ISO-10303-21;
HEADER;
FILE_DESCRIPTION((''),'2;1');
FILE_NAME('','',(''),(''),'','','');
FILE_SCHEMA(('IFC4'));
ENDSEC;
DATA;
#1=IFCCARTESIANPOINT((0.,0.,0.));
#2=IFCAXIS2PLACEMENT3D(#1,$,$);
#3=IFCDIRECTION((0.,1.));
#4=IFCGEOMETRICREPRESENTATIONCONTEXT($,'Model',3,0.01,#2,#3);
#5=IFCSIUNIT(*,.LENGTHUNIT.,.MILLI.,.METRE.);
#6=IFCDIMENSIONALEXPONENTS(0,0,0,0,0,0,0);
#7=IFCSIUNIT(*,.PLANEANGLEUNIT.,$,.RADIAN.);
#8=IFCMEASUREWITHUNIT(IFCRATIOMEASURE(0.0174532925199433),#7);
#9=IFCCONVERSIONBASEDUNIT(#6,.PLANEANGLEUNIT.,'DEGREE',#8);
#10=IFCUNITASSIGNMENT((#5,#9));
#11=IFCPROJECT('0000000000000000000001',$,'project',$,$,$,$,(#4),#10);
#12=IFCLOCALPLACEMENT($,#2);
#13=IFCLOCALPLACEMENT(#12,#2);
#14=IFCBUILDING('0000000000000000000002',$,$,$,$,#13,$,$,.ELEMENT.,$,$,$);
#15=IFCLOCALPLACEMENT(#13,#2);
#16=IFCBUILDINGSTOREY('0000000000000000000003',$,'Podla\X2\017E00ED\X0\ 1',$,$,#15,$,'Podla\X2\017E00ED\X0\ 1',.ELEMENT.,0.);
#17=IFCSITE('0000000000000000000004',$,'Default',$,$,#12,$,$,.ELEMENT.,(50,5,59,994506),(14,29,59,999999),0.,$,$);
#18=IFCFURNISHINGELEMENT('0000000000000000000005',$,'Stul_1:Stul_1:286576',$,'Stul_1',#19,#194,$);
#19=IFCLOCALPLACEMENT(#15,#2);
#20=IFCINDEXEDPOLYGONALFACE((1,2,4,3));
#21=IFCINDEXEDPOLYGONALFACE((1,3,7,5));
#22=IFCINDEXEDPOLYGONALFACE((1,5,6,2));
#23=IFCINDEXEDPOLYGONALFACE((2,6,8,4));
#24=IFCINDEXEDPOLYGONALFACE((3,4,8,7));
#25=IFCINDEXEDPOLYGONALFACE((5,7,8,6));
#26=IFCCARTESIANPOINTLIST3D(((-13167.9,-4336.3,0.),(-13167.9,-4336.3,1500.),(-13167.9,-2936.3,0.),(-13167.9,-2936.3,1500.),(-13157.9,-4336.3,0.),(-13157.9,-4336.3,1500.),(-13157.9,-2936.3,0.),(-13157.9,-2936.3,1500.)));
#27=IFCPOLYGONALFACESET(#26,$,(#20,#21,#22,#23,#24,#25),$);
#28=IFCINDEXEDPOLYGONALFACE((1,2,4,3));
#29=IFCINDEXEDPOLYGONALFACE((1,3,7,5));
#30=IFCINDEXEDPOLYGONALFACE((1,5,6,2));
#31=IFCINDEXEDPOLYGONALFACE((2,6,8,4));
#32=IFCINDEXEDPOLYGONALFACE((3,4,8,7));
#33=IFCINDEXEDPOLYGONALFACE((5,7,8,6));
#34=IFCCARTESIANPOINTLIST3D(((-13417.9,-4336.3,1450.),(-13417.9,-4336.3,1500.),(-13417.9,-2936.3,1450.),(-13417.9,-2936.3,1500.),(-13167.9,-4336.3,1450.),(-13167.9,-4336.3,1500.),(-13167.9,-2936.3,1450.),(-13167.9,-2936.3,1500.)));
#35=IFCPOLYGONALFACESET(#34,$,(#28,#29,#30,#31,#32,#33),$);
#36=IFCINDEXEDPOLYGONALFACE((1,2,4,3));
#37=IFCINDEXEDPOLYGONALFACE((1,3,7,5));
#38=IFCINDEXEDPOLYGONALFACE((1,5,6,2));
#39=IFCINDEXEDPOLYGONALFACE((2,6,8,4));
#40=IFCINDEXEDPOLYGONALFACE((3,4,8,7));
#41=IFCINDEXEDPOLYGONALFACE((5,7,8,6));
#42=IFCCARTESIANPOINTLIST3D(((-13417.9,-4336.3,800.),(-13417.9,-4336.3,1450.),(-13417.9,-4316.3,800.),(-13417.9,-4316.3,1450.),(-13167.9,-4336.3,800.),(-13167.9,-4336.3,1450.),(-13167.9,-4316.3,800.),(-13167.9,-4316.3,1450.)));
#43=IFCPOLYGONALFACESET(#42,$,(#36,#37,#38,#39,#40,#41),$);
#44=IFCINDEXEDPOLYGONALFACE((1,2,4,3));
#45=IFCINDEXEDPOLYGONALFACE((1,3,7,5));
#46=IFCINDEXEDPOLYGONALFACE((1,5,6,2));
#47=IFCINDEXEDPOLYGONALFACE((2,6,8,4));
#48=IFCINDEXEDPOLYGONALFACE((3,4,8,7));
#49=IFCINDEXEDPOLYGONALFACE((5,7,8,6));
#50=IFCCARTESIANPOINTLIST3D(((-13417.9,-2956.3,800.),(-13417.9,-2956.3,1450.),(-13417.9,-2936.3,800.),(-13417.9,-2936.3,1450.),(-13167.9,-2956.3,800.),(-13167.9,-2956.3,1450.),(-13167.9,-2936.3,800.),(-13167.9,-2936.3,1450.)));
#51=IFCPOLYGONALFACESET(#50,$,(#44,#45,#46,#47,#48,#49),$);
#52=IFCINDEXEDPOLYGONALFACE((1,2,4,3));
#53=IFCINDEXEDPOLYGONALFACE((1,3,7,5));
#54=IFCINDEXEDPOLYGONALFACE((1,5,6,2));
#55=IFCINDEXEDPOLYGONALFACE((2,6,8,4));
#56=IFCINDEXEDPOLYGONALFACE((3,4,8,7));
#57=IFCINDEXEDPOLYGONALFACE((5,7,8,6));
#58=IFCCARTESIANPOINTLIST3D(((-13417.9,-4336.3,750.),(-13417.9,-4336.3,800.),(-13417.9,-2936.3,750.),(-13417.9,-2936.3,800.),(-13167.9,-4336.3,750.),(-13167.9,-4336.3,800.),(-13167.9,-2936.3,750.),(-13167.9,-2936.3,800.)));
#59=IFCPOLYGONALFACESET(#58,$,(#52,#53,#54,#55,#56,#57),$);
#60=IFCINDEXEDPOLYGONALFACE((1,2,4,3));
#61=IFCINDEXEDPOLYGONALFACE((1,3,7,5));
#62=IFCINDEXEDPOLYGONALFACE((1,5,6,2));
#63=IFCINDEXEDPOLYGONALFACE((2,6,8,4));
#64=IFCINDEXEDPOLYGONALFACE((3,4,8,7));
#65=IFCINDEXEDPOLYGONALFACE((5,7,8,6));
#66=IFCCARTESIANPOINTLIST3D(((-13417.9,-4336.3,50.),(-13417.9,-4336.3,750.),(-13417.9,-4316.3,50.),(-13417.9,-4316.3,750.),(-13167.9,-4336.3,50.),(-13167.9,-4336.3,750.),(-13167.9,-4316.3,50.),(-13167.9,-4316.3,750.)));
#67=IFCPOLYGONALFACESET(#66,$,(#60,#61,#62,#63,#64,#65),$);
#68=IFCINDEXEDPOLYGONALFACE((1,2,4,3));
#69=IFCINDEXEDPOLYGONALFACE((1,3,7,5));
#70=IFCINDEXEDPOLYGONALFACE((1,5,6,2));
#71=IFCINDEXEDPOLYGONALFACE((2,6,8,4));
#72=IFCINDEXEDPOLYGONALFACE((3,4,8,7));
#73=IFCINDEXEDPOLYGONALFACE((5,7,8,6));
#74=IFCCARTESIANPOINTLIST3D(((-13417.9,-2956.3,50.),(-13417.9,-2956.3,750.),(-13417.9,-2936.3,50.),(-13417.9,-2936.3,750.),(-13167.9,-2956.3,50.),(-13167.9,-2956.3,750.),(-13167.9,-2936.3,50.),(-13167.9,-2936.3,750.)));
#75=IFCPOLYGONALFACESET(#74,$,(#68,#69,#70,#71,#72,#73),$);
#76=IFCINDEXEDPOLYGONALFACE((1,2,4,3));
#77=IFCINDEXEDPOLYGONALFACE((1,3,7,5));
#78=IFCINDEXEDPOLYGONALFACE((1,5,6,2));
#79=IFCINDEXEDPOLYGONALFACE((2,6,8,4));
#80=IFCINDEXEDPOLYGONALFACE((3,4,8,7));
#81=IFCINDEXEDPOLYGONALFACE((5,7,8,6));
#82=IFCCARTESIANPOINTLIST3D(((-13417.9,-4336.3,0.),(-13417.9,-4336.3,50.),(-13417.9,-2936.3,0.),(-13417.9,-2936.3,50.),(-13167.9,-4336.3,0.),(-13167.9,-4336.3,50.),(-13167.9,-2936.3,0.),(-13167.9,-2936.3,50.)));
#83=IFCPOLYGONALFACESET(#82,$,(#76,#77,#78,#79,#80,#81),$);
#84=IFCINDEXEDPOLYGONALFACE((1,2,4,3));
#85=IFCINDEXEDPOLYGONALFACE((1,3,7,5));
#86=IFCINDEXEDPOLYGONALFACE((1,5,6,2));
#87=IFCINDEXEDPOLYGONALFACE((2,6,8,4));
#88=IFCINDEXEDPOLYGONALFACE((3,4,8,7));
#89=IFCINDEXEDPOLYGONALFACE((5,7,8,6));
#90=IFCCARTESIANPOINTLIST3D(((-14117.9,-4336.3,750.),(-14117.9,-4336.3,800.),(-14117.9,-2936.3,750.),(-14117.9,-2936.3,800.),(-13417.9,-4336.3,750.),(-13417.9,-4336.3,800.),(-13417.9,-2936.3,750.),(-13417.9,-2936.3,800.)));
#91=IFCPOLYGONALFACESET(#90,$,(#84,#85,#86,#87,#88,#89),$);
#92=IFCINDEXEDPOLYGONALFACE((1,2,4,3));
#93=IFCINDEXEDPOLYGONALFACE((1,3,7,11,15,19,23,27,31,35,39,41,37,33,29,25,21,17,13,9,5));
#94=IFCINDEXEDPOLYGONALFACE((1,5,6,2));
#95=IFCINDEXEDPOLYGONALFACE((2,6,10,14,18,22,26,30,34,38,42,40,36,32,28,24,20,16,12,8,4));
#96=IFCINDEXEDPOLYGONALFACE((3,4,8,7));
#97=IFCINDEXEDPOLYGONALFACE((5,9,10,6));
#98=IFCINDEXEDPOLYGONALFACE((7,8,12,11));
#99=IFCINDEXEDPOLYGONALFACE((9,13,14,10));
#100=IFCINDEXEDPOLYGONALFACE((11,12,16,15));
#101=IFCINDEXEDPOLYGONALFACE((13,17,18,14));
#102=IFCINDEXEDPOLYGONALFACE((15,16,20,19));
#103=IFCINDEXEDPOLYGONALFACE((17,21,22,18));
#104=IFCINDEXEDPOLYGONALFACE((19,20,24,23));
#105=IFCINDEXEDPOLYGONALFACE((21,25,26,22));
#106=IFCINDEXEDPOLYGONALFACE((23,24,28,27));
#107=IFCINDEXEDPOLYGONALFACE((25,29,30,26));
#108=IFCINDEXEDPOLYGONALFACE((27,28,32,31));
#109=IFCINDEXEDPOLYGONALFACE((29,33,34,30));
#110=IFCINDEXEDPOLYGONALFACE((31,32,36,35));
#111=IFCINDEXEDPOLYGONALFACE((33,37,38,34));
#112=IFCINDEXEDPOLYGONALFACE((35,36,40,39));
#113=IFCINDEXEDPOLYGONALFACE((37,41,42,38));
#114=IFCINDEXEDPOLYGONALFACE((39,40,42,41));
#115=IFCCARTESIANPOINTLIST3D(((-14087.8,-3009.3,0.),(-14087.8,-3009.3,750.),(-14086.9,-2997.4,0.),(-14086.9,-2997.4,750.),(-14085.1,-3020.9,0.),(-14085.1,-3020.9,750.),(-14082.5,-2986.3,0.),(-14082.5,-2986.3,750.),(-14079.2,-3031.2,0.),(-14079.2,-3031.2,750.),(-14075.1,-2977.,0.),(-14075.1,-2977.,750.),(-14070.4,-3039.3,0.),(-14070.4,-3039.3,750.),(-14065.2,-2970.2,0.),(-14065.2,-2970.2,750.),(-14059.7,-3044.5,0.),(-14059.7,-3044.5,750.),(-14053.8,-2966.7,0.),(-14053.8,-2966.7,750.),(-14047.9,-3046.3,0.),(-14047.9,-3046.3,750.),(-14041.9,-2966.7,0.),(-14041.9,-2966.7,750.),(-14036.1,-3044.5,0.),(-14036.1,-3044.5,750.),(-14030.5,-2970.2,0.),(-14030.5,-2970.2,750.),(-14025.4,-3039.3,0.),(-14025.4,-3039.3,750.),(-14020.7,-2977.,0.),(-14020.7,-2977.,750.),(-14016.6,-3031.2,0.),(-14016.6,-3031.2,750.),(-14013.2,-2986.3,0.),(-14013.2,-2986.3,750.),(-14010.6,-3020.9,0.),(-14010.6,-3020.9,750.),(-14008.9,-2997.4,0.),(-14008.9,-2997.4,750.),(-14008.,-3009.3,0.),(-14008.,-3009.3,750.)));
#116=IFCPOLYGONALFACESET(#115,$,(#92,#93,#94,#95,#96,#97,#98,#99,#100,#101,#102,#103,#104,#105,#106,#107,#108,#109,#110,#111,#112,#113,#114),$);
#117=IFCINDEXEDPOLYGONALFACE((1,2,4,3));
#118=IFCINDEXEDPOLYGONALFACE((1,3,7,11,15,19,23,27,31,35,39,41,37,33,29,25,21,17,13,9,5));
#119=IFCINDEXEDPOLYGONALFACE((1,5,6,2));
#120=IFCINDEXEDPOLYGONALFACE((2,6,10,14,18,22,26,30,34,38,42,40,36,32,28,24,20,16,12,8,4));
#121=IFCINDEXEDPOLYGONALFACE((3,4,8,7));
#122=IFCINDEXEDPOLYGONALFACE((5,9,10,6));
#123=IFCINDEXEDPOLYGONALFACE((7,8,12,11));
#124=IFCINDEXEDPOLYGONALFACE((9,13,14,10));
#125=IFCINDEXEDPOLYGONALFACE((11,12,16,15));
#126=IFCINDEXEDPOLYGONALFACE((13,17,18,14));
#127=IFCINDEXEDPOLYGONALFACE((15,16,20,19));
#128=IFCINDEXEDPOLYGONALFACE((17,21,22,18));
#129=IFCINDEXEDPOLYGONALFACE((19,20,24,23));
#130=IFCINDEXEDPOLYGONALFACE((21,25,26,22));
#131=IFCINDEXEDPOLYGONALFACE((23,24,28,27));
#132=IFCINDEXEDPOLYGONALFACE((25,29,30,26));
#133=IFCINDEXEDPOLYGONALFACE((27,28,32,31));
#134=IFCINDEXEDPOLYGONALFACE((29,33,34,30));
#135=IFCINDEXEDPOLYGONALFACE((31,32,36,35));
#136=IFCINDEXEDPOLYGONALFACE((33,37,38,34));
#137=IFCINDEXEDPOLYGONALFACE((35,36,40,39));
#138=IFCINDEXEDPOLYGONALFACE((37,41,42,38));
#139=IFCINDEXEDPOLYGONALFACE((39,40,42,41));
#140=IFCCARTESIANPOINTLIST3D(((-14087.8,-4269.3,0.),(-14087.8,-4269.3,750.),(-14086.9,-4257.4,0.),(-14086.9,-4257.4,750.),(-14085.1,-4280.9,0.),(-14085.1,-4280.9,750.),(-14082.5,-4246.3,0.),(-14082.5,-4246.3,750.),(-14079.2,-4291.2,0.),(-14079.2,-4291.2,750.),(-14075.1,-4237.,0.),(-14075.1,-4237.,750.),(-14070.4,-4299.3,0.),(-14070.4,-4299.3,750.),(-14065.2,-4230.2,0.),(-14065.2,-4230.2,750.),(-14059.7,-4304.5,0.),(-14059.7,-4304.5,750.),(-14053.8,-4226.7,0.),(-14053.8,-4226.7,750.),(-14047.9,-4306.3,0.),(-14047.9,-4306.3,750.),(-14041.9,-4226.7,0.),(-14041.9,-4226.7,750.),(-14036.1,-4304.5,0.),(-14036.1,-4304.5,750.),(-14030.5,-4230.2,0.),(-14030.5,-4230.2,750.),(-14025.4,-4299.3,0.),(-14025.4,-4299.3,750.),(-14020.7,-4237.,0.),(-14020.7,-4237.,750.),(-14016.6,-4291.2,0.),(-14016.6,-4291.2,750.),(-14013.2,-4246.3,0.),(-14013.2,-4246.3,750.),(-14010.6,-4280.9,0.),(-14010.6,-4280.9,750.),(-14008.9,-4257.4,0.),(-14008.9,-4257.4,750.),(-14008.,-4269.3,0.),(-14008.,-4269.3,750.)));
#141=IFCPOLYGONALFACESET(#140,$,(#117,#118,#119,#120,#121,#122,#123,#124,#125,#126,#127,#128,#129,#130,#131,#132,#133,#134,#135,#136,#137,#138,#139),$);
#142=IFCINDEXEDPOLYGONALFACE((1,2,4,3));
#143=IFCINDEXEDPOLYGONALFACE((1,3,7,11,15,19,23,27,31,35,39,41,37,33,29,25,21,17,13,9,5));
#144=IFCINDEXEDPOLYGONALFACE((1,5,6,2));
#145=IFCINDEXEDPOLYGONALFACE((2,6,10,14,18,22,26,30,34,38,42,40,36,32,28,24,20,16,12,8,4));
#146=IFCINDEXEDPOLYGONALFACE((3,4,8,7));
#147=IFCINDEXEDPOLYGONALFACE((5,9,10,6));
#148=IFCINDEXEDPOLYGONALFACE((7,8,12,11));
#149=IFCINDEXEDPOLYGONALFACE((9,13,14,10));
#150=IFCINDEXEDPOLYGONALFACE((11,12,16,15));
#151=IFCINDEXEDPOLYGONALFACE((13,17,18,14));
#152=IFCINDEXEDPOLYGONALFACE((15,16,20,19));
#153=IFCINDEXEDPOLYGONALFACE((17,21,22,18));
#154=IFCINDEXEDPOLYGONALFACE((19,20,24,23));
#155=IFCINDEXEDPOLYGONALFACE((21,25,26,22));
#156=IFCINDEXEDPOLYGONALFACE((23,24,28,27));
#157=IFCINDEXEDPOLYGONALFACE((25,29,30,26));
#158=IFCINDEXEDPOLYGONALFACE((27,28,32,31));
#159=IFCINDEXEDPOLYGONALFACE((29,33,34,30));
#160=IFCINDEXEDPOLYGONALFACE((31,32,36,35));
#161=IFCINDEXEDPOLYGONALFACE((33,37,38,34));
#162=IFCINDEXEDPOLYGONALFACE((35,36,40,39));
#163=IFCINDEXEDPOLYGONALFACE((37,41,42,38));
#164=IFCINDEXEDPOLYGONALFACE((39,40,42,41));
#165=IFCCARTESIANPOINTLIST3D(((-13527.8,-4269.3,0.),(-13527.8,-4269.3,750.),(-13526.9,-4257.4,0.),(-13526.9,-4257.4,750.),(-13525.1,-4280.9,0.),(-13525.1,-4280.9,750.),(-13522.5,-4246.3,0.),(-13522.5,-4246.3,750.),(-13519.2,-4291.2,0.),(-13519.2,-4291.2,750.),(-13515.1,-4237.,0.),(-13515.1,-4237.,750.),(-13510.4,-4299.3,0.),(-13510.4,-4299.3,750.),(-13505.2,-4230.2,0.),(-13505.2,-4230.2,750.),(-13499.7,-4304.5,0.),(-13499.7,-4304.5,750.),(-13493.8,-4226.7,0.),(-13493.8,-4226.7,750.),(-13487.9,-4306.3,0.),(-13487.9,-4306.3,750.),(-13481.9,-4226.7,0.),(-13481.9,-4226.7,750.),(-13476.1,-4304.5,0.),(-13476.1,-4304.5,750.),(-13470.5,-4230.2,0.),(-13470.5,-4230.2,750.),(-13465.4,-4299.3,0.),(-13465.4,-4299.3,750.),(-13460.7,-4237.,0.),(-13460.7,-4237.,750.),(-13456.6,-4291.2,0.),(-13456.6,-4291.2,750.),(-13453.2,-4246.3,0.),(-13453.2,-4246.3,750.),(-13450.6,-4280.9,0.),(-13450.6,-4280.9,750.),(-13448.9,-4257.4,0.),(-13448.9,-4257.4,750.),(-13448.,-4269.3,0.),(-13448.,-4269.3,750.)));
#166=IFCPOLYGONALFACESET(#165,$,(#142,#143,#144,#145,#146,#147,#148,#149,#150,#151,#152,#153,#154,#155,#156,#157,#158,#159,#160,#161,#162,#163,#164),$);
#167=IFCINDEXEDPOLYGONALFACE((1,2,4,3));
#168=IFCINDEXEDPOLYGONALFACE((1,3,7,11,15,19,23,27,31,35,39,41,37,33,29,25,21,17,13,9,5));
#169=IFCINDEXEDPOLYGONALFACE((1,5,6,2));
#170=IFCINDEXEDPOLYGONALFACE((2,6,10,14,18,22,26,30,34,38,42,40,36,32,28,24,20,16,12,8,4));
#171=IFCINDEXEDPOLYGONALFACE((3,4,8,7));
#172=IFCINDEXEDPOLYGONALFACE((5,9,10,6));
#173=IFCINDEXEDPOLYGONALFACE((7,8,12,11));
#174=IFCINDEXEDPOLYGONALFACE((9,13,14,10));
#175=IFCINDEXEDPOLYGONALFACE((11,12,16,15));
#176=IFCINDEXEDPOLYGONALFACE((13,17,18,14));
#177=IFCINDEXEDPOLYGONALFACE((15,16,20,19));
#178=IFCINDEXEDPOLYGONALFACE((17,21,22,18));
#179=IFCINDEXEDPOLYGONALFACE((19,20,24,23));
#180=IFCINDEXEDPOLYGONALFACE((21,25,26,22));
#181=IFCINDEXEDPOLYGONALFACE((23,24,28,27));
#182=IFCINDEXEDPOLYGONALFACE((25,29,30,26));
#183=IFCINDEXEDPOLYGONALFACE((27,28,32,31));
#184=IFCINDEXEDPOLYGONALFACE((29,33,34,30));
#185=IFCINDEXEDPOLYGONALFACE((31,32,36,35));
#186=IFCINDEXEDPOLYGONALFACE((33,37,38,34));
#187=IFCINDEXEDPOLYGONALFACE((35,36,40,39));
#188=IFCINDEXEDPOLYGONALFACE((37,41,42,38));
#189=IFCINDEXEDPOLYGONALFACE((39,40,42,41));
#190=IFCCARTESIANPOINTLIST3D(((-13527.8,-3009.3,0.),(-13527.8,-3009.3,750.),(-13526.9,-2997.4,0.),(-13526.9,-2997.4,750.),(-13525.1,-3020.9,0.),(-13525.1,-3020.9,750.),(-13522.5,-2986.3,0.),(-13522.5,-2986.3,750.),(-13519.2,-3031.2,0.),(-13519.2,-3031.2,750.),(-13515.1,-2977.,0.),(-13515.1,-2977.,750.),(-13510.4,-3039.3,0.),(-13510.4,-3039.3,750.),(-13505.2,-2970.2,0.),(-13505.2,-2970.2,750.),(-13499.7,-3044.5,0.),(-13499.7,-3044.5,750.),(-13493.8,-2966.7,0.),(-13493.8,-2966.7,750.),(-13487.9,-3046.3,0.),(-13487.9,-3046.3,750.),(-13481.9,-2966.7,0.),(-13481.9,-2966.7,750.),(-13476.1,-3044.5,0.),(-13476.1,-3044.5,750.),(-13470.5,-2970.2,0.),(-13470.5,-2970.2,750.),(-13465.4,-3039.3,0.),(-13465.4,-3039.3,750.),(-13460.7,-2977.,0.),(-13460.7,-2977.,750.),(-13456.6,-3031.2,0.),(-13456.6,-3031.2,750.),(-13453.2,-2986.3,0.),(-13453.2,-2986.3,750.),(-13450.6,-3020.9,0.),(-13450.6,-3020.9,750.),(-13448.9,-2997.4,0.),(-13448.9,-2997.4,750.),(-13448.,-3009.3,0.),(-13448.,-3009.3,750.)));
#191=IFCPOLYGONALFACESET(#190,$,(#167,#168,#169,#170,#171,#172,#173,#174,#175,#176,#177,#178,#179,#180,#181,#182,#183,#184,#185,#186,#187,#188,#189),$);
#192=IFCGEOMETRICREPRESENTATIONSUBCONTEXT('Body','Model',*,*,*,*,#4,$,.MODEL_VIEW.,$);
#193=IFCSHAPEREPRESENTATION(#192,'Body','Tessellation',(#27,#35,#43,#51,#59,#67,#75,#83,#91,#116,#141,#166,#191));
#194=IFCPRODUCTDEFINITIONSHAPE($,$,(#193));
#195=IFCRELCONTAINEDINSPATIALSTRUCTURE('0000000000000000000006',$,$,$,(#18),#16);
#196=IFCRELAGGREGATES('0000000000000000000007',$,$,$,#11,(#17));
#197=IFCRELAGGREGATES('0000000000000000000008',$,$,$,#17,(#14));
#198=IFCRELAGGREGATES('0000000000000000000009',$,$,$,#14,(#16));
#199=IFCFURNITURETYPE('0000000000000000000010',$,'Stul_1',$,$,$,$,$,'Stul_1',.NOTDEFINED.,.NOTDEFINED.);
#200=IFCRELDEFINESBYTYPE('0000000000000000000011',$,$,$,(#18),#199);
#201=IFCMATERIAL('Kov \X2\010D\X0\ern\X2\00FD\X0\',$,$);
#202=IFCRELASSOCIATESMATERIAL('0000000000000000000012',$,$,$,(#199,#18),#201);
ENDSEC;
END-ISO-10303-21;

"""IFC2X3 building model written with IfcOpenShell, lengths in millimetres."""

from ifc_helpers import new_model, entity, si_unit, converted_unit, direction, frame, frame_2d, origin, origin_2d_with_axis, place, context, subcontext, project, spatial, rectangle, circle, extrude, source, transform, mapped, material, type_object, type_shapes, element, save


model = new_model("IFC2X3")

# Units and contexts
model_context = context("Model", 3, precision=0.01, world=origin(), true_north=direction((0.0, 1.0)))
body_context = subcontext(model_context, "Body", "Model", "MODEL_VIEW")
ifc_project = project(units=[si_unit("LENGTHUNIT", "METRE", prefix="MILLI"), converted_unit("PLANEANGLEUNIT", "DEGREE", entity("IfcRatioMeasure", 0.0174532925199433), si_unit("PLANEANGLEUNIT", "RADIAN"), dimensions=[0, 0, 0, 0, 0, 0, 0])], contexts=[model_context])

# Site, building, storey
site_placement = place(None, origin())
site = spatial("IfcSite", under=ifc_project, at=site_placement, Name="Default", CompositionType="ELEMENT", RefLatitude=(50, 5, 59, 994506), RefLongitude=(14, 29, 59, 999999), RefElevation=0.0)
building_placement = place(site_placement, origin())
building = spatial("IfcBuilding", under=site, at=building_placement, CompositionType="ELEMENT")
storey_placement = place(building_placement, origin())
storey = spatial("IfcBuildingStorey", under=building, at=storey_placement, Name="Podlaží 1", LongName="Podlaží 1", CompositionType="ELEMENT", Elevation=0.0)

# Furnishing element
ifc_material_1 = material(Name="Kov černý")
furniture_type = type_object("IfcFurnitureType", Name="Stul_1", ElementType="Stul_1", material=ifc_material_1)
shared_shape_1 = source(origin(), body_context, "Body", "SweptSolid", [
    extrude(rectangle(XDim=1400.0, YDim=10.0, at=origin_2d_with_axis()), frame((0.0, 605.0, 0.0), z_axis=(0.0, 0.0, 1.0), x_axis=(-1.0, 0.0, 0.0)), (0.0, 0.0, 1.0), 1500.0),
    extrude(rectangle(XDim=1400.0, YDim=250.0, at=frame_2d((0.0, 0.0), x_axis=(1.0, 0.0))), frame((0.0, 475.0, 1450.0), z_axis=(0.0, 0.0, 1.0), x_axis=(-1.0, 0.0, 0.0)), (0.0, 0.0, 1.0), 50.0),
    extrude(rectangle(XDim=20.0, YDim=250.0, at=origin_2d_with_axis()), frame((690.0, 475.0, 800.0), z_axis=(0.0, 0.0, 1.0), x_axis=(-1.0, 0.0, 0.0)), (0.0, 0.0, 1.0), 650.0),
    extrude(rectangle(XDim=20.0, YDim=250.0, at=frame_2d((0.0, 0.0), x_axis=(1.0, 0.0))), frame((-690.0, 475.0, 800.0), z_axis=(0.0, 0.0, 1.0), x_axis=(-1.0, 0.0, 0.0)), (0.0, 0.0, 1.0), 650.0),
    extrude(rectangle(XDim=1400.0, YDim=250.0, at=origin_2d_with_axis()), frame((0.0, 475.0, 750.0), z_axis=(0.0, 0.0, 1.0), x_axis=(-1.0, 0.0, 0.0)), (0.0, 0.0, 1.0), 50.0),
    extrude(rectangle(XDim=20.0, YDim=250.0, at=origin_2d_with_axis()), frame((690.0, 475.0, 50.0), z_axis=(0.0, 0.0, 1.0), x_axis=(-1.0, 0.0, 0.0)), (0.0, 0.0, 1.0), 700.0),
    extrude(rectangle(XDim=20.0, YDim=250.0, at=frame_2d((0.0, 0.0), x_axis=(1.0, 0.0))), frame((-690.0, 475.0, 50.0), z_axis=(0.0, 0.0, 1.0), x_axis=(-1.0, 0.0, 0.0)), (0.0, 0.0, 1.0), 700.0),
    extrude(rectangle(XDim=1400.0, YDim=250.0, at=origin_2d_with_axis()), frame((0.0, 475.0, 0.0), z_axis=(0.0, 0.0, 1.0), x_axis=(-1.0, 0.0, 0.0)), (0.0, 0.0, 1.0), 50.0),
    extrude(rectangle(XDim=1400.0, YDim=700.0, at=origin_2d_with_axis()), frame((0.0, 0.0, 750.0), z_axis=(0.0, 0.0, 1.0), x_axis=(-1.0, 0.0, 0.0)), (0.0, 0.0, 1.0), 50.0),
    extrude(circle(Radius=40.0, at=frame_2d((0.0, 0.0), x_axis=(1.0, 0.0))), frame((-630.0, -280.0, 0.0)), (0.0, 0.0, 1.0), 750.0),
    extrude(circle(Radius=40.0, at=frame_2d((0.0, 0.0), x_axis=(1.0, 0.0))), frame((630.0, -280.0, 0.0)), (0.0, 0.0, 1.0), 750.0),
    extrude(circle(Radius=40.0, at=frame_2d((0.0, 0.0), x_axis=(1.0, 0.0))), frame((630.0, 280.0, 0.0)), (0.0, 0.0, 1.0), 750.0),
    extrude(circle(Radius=40.0, at=frame_2d((0.0, 0.0), x_axis=(1.0, 0.0))), frame((-630.0, 280.0, 0.0)), (0.0, 0.0, 1.0), 750.0),
])
type_shapes(furniture_type, [shared_shape_1])
for number, where, z_axis, x_axis, name in (
    (1, (-13767.9, -3636.3, 0.0), (0.0, 0.0, 1.0), (0.0, -1.0, 0.0), "Stul_1:Stul_1:286576"),
):
    element("IfcFurnishingElement", number, at=place(storey_placement, frame(where, z_axis=z_axis, x_axis=x_axis)), inside=storey, type_object=furniture_type, material=ifc_material_1, Name=name, ObjectType="Stul_1", context=body_context, shape_type="MappedRepresentation", body=[
        mapped(shared_shape_1, transform((0.0, 0.0, 0.0), scale=1.0)),
    ])

save(model, "model.ifc")
